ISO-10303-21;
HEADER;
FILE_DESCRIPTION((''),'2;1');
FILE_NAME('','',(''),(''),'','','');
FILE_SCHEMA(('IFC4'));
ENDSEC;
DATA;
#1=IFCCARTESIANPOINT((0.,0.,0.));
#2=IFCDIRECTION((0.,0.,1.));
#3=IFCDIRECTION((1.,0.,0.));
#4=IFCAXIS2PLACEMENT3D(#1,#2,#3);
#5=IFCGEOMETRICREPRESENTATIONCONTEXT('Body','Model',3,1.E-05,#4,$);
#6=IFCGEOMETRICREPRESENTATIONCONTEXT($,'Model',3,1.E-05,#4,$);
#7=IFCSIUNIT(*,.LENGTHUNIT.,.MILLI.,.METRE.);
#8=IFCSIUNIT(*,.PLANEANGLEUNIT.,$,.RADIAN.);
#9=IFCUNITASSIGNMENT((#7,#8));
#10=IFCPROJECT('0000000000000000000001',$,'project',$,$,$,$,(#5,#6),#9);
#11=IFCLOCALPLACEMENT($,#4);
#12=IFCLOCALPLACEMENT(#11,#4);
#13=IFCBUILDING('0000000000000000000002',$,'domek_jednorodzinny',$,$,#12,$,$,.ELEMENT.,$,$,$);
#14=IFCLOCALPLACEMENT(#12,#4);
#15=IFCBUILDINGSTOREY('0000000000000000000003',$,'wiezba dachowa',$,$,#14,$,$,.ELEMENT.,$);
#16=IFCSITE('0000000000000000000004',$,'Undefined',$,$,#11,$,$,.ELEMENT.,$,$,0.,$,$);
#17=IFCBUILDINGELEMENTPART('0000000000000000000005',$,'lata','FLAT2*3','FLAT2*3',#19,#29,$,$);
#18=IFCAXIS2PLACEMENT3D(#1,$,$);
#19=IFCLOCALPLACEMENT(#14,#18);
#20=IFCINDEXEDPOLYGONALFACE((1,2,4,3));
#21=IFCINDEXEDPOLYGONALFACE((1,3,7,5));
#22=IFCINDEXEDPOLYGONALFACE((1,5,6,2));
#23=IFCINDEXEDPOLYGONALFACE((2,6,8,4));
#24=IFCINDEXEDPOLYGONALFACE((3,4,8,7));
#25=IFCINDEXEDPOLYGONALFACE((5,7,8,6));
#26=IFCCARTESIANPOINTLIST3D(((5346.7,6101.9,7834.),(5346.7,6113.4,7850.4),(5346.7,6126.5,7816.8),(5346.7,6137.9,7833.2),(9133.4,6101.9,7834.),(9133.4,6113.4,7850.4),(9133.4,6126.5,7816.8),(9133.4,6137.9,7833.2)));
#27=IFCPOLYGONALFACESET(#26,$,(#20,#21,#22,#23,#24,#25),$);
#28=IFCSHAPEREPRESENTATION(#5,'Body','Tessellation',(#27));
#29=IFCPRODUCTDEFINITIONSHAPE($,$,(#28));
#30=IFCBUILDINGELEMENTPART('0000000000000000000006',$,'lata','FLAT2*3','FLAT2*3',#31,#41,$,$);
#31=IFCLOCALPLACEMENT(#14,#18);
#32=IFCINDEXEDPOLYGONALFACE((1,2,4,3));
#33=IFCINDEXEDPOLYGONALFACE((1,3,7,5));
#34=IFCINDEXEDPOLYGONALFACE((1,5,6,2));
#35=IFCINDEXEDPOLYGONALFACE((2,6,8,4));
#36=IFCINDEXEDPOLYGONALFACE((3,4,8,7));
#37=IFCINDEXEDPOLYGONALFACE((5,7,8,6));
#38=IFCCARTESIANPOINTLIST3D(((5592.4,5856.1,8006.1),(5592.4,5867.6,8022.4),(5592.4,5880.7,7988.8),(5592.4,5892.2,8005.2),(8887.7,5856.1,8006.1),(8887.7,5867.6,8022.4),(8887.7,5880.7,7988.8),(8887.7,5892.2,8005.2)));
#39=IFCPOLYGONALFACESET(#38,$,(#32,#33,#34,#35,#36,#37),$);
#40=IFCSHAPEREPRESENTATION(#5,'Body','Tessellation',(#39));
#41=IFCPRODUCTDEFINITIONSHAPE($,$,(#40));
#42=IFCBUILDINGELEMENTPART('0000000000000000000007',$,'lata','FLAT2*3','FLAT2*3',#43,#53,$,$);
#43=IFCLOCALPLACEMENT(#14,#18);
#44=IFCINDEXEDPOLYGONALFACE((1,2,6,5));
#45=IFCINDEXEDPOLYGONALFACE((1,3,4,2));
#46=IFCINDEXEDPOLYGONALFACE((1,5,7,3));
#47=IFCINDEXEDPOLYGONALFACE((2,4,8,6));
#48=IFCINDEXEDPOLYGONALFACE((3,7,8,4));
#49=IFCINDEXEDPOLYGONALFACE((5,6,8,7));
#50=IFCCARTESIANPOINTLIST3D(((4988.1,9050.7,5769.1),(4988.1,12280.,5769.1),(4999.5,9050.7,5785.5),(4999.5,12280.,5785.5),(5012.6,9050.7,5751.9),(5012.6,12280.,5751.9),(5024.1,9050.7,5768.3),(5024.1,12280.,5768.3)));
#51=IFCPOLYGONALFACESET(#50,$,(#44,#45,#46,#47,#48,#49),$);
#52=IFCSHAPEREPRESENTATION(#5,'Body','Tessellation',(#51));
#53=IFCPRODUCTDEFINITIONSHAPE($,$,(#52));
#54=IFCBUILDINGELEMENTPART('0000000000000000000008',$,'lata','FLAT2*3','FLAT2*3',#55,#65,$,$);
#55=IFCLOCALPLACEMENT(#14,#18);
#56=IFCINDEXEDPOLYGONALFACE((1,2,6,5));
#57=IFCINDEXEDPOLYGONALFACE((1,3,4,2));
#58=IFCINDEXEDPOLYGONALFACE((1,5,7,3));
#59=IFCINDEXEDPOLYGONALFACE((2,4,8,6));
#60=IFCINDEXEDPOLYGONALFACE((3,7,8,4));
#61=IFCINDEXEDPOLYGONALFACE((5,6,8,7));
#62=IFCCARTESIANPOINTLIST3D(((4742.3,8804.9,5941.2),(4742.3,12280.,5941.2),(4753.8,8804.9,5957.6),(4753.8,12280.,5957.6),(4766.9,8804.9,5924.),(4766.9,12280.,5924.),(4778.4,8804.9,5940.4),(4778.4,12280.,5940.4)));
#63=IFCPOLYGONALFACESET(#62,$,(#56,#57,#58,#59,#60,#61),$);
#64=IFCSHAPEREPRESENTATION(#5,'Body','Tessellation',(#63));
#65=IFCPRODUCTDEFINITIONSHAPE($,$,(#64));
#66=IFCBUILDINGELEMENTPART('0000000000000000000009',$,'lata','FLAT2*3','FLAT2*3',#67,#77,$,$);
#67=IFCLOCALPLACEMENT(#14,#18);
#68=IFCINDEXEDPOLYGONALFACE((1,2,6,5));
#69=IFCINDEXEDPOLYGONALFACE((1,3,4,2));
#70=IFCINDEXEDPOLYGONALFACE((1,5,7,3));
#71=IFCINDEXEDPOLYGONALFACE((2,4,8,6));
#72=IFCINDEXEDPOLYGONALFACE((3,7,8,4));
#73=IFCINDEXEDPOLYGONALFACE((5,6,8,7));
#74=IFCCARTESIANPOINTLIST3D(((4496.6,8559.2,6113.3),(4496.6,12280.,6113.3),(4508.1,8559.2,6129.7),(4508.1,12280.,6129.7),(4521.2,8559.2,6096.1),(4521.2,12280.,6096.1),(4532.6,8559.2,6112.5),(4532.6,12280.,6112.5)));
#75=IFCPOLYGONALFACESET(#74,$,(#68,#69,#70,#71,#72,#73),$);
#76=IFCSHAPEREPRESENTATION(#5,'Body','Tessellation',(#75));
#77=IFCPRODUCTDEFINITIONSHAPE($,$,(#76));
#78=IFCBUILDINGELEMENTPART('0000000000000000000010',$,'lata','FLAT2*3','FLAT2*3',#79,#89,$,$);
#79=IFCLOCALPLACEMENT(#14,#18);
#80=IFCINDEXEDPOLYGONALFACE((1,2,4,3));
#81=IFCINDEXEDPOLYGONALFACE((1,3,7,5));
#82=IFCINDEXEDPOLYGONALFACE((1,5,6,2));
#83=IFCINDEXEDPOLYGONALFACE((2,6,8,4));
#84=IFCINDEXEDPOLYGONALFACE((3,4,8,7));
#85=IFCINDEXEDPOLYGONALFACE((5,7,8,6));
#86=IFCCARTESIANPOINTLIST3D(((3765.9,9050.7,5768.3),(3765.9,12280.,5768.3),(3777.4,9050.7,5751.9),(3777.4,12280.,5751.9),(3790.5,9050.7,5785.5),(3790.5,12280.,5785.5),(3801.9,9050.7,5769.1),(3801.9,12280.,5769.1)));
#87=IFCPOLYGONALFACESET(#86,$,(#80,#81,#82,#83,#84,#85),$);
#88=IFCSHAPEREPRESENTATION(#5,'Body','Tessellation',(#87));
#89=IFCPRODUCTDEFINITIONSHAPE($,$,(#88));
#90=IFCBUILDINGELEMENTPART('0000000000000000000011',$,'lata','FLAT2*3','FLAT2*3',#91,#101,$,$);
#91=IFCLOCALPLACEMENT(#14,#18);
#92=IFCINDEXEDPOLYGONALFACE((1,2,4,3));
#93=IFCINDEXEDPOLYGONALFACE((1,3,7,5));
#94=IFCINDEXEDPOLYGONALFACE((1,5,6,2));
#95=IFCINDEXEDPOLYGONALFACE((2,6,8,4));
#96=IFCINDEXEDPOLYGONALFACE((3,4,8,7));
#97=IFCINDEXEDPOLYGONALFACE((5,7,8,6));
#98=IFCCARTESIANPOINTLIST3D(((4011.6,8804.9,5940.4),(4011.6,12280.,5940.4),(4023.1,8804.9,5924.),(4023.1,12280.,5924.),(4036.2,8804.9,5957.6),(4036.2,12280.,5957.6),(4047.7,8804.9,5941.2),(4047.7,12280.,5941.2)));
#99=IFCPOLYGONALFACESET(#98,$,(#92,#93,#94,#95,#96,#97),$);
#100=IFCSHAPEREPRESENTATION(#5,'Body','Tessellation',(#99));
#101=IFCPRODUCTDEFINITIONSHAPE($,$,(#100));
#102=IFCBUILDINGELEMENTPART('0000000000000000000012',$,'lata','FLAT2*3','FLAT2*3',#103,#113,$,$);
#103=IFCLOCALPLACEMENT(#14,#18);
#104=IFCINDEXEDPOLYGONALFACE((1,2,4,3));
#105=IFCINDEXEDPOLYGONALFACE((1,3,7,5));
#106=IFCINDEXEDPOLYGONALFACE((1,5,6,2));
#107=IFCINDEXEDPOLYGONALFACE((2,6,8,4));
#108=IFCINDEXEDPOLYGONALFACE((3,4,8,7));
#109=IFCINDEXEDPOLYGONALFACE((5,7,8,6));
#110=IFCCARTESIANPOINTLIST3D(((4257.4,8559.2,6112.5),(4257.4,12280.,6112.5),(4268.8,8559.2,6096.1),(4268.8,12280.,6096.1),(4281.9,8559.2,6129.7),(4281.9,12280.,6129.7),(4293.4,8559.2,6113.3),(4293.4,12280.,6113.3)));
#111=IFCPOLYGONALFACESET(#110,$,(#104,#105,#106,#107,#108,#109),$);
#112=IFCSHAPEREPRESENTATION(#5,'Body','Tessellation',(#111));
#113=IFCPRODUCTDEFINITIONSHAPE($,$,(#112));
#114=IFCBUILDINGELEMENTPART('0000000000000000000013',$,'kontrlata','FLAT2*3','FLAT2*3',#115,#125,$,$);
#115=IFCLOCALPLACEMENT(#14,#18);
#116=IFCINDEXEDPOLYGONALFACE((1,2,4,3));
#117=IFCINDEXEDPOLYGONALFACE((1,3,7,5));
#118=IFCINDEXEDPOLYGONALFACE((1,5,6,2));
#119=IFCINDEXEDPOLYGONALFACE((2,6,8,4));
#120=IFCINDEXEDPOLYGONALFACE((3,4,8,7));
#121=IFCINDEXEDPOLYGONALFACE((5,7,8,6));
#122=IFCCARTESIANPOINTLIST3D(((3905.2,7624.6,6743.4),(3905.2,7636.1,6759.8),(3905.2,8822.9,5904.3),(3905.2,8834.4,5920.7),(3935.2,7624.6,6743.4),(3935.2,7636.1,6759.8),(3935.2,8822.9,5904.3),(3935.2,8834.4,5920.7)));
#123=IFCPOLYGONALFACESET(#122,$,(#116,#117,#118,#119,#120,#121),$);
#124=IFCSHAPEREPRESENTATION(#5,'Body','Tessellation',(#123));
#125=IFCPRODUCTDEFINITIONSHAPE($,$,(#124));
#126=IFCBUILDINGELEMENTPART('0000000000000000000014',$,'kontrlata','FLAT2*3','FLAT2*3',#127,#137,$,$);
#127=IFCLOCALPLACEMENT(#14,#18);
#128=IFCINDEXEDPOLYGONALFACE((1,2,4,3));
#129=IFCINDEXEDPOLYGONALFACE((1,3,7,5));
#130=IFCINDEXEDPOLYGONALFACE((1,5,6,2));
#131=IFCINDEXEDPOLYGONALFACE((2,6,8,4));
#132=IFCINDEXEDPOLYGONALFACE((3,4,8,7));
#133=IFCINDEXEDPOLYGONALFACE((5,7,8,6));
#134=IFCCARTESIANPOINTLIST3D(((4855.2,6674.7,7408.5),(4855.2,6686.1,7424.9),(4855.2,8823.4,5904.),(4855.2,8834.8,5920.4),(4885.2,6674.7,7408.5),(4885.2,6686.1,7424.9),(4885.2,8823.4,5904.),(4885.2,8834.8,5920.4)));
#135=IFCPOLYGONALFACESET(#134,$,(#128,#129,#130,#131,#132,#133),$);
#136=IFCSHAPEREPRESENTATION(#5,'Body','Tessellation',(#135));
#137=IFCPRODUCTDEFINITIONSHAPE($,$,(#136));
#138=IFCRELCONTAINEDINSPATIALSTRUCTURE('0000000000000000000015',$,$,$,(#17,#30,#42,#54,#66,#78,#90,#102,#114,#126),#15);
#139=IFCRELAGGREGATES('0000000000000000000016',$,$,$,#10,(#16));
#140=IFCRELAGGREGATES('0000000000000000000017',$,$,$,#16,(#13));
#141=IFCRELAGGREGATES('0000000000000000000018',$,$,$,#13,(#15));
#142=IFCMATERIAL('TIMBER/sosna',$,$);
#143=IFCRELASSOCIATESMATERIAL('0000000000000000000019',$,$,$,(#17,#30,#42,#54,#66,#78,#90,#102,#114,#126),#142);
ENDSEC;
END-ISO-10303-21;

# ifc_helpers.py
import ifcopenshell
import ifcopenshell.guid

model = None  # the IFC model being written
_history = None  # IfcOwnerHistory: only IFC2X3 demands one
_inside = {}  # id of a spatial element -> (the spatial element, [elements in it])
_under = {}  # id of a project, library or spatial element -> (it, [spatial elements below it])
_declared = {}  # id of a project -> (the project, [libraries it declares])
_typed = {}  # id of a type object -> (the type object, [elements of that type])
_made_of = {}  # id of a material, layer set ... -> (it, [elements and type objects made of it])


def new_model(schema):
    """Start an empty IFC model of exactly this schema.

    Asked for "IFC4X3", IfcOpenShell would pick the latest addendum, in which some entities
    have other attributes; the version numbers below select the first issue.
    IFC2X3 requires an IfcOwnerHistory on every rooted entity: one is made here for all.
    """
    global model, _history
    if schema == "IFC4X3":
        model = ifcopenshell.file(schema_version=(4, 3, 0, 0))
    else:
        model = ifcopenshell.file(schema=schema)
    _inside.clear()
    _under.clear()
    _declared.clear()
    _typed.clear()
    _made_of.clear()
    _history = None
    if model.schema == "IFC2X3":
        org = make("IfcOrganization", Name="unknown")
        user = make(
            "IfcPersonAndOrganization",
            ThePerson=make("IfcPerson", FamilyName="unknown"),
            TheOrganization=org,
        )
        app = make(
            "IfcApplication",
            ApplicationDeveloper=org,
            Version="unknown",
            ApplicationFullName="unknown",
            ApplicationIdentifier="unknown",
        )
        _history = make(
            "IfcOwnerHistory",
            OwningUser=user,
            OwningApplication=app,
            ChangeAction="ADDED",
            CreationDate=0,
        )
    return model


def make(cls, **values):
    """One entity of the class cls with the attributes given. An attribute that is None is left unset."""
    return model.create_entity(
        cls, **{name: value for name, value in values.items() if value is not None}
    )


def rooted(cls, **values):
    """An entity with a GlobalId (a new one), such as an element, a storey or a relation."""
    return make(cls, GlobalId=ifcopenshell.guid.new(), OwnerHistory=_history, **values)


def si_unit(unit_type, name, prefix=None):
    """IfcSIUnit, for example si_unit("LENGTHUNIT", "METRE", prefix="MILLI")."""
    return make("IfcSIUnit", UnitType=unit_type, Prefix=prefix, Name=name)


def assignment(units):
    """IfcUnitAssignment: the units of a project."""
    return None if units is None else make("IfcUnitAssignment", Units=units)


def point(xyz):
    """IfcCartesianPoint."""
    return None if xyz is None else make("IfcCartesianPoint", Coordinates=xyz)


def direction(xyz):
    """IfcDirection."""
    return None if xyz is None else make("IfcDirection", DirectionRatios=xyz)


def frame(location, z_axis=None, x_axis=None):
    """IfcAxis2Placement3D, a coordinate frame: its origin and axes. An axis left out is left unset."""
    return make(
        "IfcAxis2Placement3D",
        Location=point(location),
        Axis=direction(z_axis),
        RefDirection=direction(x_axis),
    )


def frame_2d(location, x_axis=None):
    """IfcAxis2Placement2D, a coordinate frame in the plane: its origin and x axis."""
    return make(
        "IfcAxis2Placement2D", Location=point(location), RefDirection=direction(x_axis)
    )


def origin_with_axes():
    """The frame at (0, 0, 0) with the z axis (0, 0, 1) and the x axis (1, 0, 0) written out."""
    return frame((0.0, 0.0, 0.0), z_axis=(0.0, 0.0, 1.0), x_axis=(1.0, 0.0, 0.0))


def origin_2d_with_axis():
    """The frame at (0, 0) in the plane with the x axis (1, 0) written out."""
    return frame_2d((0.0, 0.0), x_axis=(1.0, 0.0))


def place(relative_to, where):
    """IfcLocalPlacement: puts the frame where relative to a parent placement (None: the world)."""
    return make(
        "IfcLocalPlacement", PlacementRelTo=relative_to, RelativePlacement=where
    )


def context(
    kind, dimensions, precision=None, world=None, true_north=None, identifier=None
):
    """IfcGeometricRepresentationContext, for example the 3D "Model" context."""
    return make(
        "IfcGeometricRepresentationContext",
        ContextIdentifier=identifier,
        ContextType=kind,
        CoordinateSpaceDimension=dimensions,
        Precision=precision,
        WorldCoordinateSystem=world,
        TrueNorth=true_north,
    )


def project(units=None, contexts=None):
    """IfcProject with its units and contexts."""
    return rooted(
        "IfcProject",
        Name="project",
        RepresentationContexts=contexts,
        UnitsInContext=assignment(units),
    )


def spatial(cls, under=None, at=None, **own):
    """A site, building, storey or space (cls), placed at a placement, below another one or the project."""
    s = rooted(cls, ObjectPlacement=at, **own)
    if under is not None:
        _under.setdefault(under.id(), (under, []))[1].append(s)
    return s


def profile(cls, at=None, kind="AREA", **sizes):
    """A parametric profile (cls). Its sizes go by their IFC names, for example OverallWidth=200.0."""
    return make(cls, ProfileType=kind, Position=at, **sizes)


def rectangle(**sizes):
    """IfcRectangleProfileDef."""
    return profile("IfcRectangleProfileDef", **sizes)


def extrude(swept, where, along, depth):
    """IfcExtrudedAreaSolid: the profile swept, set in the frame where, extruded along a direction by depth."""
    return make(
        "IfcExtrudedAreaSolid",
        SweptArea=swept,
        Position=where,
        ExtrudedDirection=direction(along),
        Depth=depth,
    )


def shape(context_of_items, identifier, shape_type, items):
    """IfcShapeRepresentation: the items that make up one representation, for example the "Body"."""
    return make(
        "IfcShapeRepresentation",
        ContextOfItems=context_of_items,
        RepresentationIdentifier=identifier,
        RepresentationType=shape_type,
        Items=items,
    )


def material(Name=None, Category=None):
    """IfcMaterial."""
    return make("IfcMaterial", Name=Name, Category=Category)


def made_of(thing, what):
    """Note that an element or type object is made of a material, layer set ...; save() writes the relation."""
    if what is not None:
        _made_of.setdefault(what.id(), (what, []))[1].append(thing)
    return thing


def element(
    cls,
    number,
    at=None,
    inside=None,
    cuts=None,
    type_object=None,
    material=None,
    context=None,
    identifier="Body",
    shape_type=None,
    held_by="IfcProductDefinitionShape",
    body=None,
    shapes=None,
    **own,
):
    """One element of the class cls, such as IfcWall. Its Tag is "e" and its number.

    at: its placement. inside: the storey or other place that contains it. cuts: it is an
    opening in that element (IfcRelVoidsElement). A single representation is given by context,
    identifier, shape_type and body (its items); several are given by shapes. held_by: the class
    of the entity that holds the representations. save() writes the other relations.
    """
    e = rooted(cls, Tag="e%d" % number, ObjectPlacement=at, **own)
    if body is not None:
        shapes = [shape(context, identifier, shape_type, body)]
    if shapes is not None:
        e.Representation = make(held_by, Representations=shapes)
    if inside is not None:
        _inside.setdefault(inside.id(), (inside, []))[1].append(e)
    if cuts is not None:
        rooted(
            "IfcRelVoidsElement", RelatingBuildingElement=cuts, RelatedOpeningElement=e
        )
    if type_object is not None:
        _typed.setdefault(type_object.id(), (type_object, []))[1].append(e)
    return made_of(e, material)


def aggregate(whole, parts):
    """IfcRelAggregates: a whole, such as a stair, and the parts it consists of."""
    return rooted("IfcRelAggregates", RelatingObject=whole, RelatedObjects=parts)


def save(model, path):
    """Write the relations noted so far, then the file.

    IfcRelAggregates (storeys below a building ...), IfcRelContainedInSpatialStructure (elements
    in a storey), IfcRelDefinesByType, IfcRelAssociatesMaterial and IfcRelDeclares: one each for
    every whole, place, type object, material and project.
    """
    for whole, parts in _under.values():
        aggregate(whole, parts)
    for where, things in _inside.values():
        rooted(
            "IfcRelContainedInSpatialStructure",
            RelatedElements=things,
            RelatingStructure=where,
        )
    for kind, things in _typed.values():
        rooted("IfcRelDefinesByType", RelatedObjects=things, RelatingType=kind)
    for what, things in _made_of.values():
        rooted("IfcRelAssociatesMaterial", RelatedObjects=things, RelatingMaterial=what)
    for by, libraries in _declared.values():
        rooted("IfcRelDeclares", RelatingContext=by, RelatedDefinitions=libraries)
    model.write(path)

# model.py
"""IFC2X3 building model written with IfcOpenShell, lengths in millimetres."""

from ifc_helpers import new_model, si_unit, frame, origin_with_axes, origin_2d_with_axis, place, context, project, spatial, rectangle, extrude, material, element, save


model = new_model("IFC2X3")

# Units and contexts
model_context_1 = context("Model", 3, precision=1e-05, world=origin_with_axes(), identifier="Body")
model_context_2 = context("Model", 3, precision=1e-05, world=origin_with_axes())
ifc_project = project(units=[si_unit("LENGTHUNIT", "METRE", prefix="MILLI"), si_unit("PLANEANGLEUNIT", "RADIAN")], contexts=[model_context_1, model_context_2])

# Site, building, storey
site_placement = place(None, origin_with_axes())
site = spatial("IfcSite", under=ifc_project, at=site_placement, Name="Undefined", CompositionType="ELEMENT", RefElevation=0.0)
building_placement = place(site_placement, origin_with_axes())
building = spatial("IfcBuilding", under=site, at=building_placement, Name="domek_jednorodzinny", CompositionType="ELEMENT")
storey_placement = place(building_placement, origin_with_axes())
storey = spatial("IfcBuildingStorey", under=building, at=storey_placement, Name="wiezba dachowa", CompositionType="ELEMENT")

# Building element parts
ifc_material = material(Name="TIMBER/sosna")
building_element_part_1_placement = place(storey_placement, frame((5346.7, 6119.9, 7833.6), z_axis=(0.0, -0.819154, 0.573574), x_axis=(1.0, 0.0, 0.0)))
element("IfcBuildingElementPart", 1, at=building_element_part_1_placement, inside=storey, material=ifc_material, Name="lata", Description="FLAT2*3", ObjectType="FLAT2*3", context=model_context_1, shape_type="SweptSolid", body=[
    extrude(rectangle(XDim=20.0, YDim=30.0, at=origin_2d_with_axis()), frame((3786.7, 0.0, 0.0), z_axis=(-1.0, 0.0, 0.0), x_axis=(0.0, -1.0, 0.0)), (0.0, 0.0, 1.0), 3786.7),
])
building_element_part_2_placement = place(storey_placement, frame((5592.4, 5874.2, 8005.6), z_axis=(0.0, -0.819154, 0.573574), x_axis=(1.0, 0.0, 0.0)))
element("IfcBuildingElementPart", 2, at=building_element_part_2_placement, inside=storey, material=ifc_material, Name="lata", Description="FLAT2*3", ObjectType="FLAT2*3", context=model_context_1, shape_type="SweptSolid", body=[
    extrude(rectangle(XDim=20.0, YDim=30.0, at=origin_2d_with_axis()), frame((3295.2, 0.0, 0.0), z_axis=(-1.0, 0.0, 0.0), x_axis=(0.0, -1.0, 0.0)), (0.0, 0.0, 1.0), 3295.2),
])
building_element_part_3_placement = place(storey_placement, frame((5006.1, 9050.7, 5768.7), z_axis=(-0.819152, 0.0, 0.573576), x_axis=(0.0, 1.0, 0.0)))
element("IfcBuildingElementPart", 3, at=building_element_part_3_placement, inside=storey, material=ifc_material, Name="lata", Description="FLAT2*3", ObjectType="FLAT2*3", context=model_context_1, shape_type="SweptSolid", body=[
    extrude(rectangle(XDim=20.0, YDim=30.0, at=origin_2d_with_axis()), frame((3229.3, 0.0, 0.0), z_axis=(-1.0, 0.0, 0.0), x_axis=(0.0, -1.0, 0.0)), (0.0, 0.0, 1.0), 3229.3),
])
building_element_part_4_placement = place(storey_placement, frame((4760.4, 8804.9, 5940.8), z_axis=(-0.819152, 0.0, 0.573576), x_axis=(0.0, 1.0, 0.0)))
element("IfcBuildingElementPart", 4, at=building_element_part_4_placement, inside=storey, material=ifc_material, Name="lata", Description="FLAT2*3", ObjectType="FLAT2*3", context=model_context_1, shape_type="SweptSolid", body=[
    extrude(rectangle(XDim=20.0, YDim=30.0, at=origin_2d_with_axis()), frame((3475.1, 0.0, 0.0), z_axis=(-1.0, 0.0, 0.0), x_axis=(0.0, -1.0, 0.0)), (0.0, 0.0, 1.0), 3475.1),
])
building_element_part_5_placement = place(storey_placement, frame((4514.6, 8559.2, 6112.9), z_axis=(-0.819152, 0.0, 0.573576), x_axis=(0.0, 1.0, 0.0)))
element("IfcBuildingElementPart", 5, at=building_element_part_5_placement, inside=storey, material=ifc_material, Name="lata", Description="FLAT2*3", ObjectType="FLAT2*3", context=model_context_1, shape_type="SweptSolid", body=[
    extrude(rectangle(XDim=20.0, YDim=30.0, at=origin_2d_with_axis()), frame((3720.8, 0.0, 0.0), z_axis=(-1.0, 0.0, 0.0), x_axis=(0.0, -1.0, 0.0)), (0.0, 0.0, 1.0), 3720.8),
])
building_element_part_6_placement = place(storey_placement, frame((3783.9, 9050.7, 5768.7), z_axis=(0.819152, 0.0, 0.573576), x_axis=(0.0, 1.0, 0.0)))
element("IfcBuildingElementPart", 6, at=building_element_part_6_placement, inside=storey, material=ifc_material, Name="lata", Description="FLAT2*3", ObjectType="FLAT2*3", context=model_context_1, shape_type="SweptSolid", body=[
    extrude(rectangle(XDim=20.0, YDim=30.0, at=origin_2d_with_axis()), frame((3229.3, 0.0, 0.0), z_axis=(-1.0, 0.0, 0.0), x_axis=(0.0, -1.0, 0.0)), (0.0, 0.0, 1.0), 3229.3),
])
building_element_part_7_placement = place(storey_placement, frame((4029.6, 8804.9, 5940.8), z_axis=(0.819152, 0.0, 0.573576), x_axis=(0.0, 1.0, 0.0)))
element("IfcBuildingElementPart", 7, at=building_element_part_7_placement, inside=storey, material=ifc_material, Name="lata", Description="FLAT2*3", ObjectType="FLAT2*3", context=model_context_1, shape_type="SweptSolid", body=[
    extrude(rectangle(XDim=20.0, YDim=30.0, at=origin_2d_with_axis()), frame((3475.1, 0.0, 0.0), z_axis=(-1.0, 0.0, 0.0), x_axis=(0.0, -1.0, 0.0)), (0.0, 0.0, 1.0), 3475.1),
])
building_element_part_8_placement = place(storey_placement, frame((4275.4, 8559.2, 6112.9), z_axis=(0.819152, 0.0, 0.573576), x_axis=(0.0, 1.0, 0.0)))
element("IfcBuildingElementPart", 8, at=building_element_part_8_placement, inside=storey, material=ifc_material, Name="lata", Description="FLAT2*3", ObjectType="FLAT2*3", context=model_context_1, shape_type="SweptSolid", body=[
    extrude(rectangle(XDim=20.0, YDim=30.0, at=origin_2d_with_axis()), frame((3720.8, 0.0, 0.0), z_axis=(-1.0, 0.0, 0.0), x_axis=(0.0, -1.0, 0.0)), (0.0, 0.0, 1.0), 3720.8),
])
building_element_part_9_placement = place(storey_placement, frame((3920.2, 8828.7, 5912.5), z_axis=(-1.0, 0.0, 0.0), x_axis=(0.0, -0.819154, 0.573574)))
element("IfcBuildingElementPart", 9, at=building_element_part_9_placement, inside=storey, material=ifc_material, Name="kontrlata", Description="FLAT2*3", ObjectType="FLAT2*3", context=model_context_1, shape_type="SweptSolid", body=[
    extrude(rectangle(XDim=20.0, YDim=30.0, at=origin_2d_with_axis()), frame((1462.9, 0.0, 0.0), z_axis=(-1.0, 0.0, 0.0), x_axis=(0.0, -1.0, 0.0)), (0.0, 0.0, 1.0), 1462.9),
])
building_element_part_10_placement = place(storey_placement, frame((4870.2, 8829.1, 5912.2), z_axis=(-1.0, 0.0, 0.0), x_axis=(0.0, -0.819154, 0.573574)))
element("IfcBuildingElementPart", 10, at=building_element_part_10_placement, inside=storey, material=ifc_material, Name="kontrlata", Description="FLAT2*3", ObjectType="FLAT2*3", context=model_context_1, shape_type="SweptSolid", body=[
    extrude(rectangle(XDim=20.0, YDim=30.0, at=origin_2d_with_axis()), frame((2623.1, 0.0, 0.0), z_axis=(-1.0, 0.0, 0.0), x_axis=(0.0, -1.0, 0.0)), (0.0, 0.0, 1.0), 2623.1),
])

save(model, "model.ifc")
